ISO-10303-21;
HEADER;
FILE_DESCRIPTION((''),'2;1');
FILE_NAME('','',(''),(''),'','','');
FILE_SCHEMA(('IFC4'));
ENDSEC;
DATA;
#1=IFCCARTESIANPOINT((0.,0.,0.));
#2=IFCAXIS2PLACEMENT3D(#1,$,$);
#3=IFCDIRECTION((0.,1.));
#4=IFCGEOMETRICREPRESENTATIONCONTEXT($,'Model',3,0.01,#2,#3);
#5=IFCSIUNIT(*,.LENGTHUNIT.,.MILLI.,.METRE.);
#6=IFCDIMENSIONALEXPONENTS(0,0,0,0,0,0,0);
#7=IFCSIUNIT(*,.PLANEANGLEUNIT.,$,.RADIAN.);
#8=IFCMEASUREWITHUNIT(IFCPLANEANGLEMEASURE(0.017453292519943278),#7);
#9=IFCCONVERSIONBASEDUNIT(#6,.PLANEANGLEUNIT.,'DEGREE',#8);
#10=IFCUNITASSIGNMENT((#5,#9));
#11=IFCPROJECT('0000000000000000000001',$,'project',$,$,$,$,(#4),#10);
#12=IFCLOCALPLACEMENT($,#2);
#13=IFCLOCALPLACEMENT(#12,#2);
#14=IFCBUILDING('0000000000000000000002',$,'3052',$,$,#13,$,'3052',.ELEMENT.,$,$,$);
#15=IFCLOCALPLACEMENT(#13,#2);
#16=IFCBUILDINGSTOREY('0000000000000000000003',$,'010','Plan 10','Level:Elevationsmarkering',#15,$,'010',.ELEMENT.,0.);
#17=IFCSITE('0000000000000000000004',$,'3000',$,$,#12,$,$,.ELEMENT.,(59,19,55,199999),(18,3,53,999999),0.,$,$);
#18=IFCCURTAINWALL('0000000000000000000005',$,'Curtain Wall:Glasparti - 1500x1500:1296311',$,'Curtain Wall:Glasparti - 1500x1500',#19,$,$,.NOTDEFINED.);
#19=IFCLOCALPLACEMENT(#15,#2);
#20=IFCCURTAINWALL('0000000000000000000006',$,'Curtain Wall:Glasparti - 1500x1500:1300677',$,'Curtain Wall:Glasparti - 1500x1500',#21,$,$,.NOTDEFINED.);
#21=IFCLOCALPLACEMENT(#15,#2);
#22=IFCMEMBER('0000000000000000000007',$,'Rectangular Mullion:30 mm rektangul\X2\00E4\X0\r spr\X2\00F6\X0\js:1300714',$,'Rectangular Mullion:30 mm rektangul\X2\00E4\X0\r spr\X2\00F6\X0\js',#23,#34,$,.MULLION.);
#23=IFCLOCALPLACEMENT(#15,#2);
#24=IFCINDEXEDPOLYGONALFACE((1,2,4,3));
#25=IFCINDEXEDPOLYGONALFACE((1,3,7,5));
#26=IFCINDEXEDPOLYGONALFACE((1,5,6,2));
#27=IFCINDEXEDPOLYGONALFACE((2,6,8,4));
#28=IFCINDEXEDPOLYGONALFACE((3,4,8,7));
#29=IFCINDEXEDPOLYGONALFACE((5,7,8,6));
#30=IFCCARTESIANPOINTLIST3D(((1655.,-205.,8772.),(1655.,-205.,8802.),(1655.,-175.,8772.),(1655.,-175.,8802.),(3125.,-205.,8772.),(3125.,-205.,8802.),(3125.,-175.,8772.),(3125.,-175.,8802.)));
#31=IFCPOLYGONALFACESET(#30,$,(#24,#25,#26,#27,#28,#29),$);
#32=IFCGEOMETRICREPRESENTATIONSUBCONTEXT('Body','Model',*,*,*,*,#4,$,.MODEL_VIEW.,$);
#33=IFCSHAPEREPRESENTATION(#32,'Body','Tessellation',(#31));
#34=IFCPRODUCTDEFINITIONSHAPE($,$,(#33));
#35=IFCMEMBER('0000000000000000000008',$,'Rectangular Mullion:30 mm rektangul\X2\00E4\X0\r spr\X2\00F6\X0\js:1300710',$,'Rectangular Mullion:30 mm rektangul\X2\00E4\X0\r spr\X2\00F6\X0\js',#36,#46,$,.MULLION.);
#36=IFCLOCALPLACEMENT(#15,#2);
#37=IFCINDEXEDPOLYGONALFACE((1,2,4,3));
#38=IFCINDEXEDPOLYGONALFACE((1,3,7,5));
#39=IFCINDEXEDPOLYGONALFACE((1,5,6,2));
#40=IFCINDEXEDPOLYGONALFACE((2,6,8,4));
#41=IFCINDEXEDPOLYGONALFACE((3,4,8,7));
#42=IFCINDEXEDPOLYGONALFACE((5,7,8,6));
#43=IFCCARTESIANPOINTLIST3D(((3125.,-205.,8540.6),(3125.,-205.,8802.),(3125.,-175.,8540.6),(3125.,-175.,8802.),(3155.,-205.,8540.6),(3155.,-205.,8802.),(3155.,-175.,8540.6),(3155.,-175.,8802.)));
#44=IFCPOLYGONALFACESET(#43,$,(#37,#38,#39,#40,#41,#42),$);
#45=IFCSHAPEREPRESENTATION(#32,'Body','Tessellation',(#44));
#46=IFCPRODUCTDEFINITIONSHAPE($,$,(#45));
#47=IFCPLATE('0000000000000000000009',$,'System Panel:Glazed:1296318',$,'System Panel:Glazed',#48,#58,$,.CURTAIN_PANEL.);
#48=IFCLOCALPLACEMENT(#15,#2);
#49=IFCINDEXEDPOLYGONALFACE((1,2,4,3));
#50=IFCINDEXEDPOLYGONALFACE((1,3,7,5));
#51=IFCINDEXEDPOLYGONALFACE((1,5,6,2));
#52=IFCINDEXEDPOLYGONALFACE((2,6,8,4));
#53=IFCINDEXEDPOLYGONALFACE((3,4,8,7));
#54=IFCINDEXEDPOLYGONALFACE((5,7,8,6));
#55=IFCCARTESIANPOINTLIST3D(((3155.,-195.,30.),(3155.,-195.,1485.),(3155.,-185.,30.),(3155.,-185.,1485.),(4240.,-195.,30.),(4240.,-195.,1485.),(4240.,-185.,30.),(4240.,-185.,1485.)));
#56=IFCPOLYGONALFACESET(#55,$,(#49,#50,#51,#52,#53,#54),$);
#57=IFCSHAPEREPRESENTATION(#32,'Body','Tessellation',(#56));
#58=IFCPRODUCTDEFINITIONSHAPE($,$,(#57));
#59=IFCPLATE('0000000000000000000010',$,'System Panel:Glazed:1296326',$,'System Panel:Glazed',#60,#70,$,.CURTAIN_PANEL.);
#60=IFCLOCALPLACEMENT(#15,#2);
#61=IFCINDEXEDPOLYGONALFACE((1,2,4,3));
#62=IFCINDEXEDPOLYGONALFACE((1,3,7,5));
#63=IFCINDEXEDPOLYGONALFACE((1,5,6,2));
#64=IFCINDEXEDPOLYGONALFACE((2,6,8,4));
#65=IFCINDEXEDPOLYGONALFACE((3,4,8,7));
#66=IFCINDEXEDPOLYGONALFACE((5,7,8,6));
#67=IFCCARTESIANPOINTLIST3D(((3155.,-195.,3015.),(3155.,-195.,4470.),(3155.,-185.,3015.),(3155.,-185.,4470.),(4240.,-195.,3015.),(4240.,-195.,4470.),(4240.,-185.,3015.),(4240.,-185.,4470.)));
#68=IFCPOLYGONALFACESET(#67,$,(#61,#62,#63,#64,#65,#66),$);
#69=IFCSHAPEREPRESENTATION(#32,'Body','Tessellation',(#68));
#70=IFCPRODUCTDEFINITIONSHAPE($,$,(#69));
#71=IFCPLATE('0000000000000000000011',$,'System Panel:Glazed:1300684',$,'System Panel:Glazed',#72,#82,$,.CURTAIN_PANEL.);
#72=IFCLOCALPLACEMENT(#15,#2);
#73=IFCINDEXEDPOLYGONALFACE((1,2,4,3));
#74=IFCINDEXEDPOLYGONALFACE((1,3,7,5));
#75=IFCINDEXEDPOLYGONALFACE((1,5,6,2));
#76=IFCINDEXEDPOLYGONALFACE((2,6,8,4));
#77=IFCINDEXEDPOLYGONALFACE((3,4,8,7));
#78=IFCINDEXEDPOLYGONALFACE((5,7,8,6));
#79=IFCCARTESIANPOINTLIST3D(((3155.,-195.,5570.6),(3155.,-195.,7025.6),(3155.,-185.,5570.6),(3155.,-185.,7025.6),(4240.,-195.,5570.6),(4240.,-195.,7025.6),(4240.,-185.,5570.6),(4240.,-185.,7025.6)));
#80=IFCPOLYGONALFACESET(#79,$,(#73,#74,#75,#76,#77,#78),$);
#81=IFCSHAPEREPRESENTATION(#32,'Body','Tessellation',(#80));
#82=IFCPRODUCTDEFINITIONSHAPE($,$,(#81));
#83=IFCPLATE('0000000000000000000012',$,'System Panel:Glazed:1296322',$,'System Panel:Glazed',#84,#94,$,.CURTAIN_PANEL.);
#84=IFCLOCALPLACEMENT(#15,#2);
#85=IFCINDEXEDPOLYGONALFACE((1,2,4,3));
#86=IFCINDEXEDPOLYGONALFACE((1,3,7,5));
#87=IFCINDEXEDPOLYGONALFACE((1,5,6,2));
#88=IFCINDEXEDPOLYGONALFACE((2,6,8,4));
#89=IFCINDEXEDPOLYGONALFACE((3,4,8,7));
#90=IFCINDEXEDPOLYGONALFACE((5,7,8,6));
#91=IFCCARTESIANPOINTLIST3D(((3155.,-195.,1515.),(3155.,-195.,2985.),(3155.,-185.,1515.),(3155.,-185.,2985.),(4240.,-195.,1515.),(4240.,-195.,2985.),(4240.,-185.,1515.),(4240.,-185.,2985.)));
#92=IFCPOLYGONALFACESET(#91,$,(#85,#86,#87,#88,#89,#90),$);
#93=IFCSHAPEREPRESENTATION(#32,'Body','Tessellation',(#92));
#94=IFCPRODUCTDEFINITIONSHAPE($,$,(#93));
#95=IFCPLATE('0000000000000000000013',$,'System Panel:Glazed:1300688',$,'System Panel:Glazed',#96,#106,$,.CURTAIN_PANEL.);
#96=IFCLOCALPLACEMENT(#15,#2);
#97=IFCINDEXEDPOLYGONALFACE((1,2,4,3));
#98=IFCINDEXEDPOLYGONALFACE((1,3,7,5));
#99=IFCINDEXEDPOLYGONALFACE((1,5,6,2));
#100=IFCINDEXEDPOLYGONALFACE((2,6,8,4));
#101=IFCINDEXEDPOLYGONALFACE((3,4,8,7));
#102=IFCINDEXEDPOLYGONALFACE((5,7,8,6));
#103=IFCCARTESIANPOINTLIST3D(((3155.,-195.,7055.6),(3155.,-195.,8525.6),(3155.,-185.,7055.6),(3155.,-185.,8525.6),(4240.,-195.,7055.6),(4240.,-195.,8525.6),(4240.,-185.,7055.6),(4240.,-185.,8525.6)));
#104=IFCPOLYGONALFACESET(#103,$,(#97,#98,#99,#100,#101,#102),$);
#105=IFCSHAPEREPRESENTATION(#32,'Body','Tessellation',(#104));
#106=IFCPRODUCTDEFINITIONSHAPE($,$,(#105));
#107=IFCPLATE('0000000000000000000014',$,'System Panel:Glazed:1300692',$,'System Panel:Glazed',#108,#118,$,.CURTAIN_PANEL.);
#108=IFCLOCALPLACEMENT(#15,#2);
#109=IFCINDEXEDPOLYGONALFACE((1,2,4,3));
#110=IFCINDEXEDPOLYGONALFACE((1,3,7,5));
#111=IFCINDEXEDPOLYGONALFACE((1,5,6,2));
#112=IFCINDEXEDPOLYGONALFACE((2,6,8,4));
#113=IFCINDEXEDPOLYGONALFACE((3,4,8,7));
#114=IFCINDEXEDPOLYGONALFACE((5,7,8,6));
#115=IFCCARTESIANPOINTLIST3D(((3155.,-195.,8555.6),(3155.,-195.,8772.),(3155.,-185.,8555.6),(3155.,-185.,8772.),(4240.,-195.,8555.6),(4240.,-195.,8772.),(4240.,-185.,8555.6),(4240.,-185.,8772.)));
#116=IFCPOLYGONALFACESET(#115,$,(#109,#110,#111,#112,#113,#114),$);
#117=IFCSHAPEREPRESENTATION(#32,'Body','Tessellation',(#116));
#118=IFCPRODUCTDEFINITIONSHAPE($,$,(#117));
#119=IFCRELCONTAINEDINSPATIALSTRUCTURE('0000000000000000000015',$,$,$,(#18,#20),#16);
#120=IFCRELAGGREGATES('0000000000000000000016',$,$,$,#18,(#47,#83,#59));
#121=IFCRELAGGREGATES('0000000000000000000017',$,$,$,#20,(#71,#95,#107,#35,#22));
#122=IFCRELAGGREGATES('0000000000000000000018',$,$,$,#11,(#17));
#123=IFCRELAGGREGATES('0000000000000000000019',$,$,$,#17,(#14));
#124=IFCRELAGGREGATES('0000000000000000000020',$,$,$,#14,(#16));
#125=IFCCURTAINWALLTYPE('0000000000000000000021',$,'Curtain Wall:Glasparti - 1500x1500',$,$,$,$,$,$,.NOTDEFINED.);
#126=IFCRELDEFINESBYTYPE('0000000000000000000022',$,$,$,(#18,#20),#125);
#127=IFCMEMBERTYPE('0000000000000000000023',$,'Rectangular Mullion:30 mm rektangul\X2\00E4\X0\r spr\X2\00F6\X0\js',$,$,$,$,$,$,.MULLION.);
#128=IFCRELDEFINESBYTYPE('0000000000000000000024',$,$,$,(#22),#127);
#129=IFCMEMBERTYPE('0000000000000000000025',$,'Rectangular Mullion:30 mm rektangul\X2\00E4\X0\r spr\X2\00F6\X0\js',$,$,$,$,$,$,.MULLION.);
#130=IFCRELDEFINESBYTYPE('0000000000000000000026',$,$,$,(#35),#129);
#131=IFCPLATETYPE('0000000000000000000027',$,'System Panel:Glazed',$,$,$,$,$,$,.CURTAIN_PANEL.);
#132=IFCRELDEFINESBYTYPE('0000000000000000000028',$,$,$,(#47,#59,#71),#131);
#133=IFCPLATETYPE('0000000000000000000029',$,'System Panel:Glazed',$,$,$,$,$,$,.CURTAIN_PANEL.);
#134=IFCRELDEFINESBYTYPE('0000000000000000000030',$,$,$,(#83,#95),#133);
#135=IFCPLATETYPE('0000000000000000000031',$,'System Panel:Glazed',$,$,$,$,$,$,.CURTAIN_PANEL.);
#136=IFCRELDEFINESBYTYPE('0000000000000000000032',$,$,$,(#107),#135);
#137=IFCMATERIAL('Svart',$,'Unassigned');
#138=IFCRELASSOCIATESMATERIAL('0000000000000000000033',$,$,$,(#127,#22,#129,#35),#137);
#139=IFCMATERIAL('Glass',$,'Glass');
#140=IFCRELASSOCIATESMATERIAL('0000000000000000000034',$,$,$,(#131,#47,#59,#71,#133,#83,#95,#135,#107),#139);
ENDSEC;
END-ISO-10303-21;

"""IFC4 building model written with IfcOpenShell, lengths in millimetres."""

from ifc_helpers import new_model, entity, si_unit, converted_unit, direction, frame, origin, place, context, subcontext, project, spatial, indexed_curve, outline, extrude, source, transform, mapped, material, type_object, type_shapes, element, aggregate, save


model = new_model("IFC4")

# Units and contexts
model_context = context("Model", 3, precision=0.01, world=origin(), true_north=direction((0.0, 1.0)))
body_context = subcontext(model_context, "Body", "Model", "MODEL_VIEW")
ifc_project = project(units=[si_unit("LENGTHUNIT", "METRE", prefix="MILLI"), converted_unit("PLANEANGLEUNIT", "DEGREE", entity("IfcPlaneAngleMeasure", 0.017453292519943278), si_unit("PLANEANGLEUNIT", "RADIAN"), dimensions=[0, 0, 0, 0, 0, 0, 0])], contexts=[model_context])

# Site, building, storey
site_placement = place(None, origin())
site = spatial("IfcSite", under=ifc_project, at=site_placement, Name="3000", CompositionType="ELEMENT", RefLatitude=(59, 19, 55, 199999), RefLongitude=(18, 3, 53, 999999), RefElevation=0.0)
building_placement = place(site_placement, origin())
building = spatial("IfcBuilding", under=site, at=building_placement, Name="3052", LongName="3052", CompositionType="ELEMENT")
storey_placement = place(building_placement, origin())
storey = spatial("IfcBuildingStorey", under=building, at=storey_placement, Name="010", Description="Plan 10", ObjectType="Level:Elevationsmarkering", LongName="010", CompositionType="ELEMENT", Elevation=0.0)

# Curtain walls
curtain_wall_type = type_object("IfcCurtainWallType", Name="Curtain Wall:Glasparti - 1500x1500", PredefinedType="NOTDEFINED")
curtain_wall_1_placement = place(storey_placement, origin())
curtain_wall_1 = element("IfcCurtainWall", 1, at=curtain_wall_1_placement, inside=storey, type_object=curtain_wall_type, Name="Curtain Wall:Glasparti - 1500x1500:1296311", ObjectType="Curtain Wall:Glasparti - 1500x1500", PredefinedType="NOTDEFINED")
ifc_material_1 = material(Name="Svart", Category="Unassigned")
curtain_wall_2_placement = place(storey_placement, origin())
curtain_wall_2 = element("IfcCurtainWall", 2, at=curtain_wall_2_placement, inside=storey, type_object=curtain_wall_type, Name="Curtain Wall:Glasparti - 1500x1500:1300677", ObjectType="Curtain Wall:Glasparti - 1500x1500", PredefinedType="NOTDEFINED")

# Members
member_type_1 = type_object("IfcMemberType", Name="Rectangular Mullion:30 mm rektangulär spröjs", PredefinedType="MULLION", material=ifc_material_1)
shared_shape_1 = source(origin(), body_context, "Body", "SweptSolid", [
    extrude(outline(indexed_curve([(-15.0, -15.0), (15.0, -15.0), (15.0, 15.0), (-15.0, 15.0), (-15.0, -15.0)], self_intersect=False)), frame((-15.0, 0.0, -1470.0), z_axis=(0.0, 0.0, 1.0), x_axis=(-1.0, 0.0, 0.0)), (0.0, 0.0, 1.0), 1470.0),
])
type_shapes(member_type_1, [shared_shape_1])
member_1_placement = place(curtain_wall_2_placement, frame((3125.0, -190.0, 8802.0), z_axis=(1.0, 0.0, 0.0), x_axis=(0.0, 0.0, 1.0)))
member_1 = element("IfcMember", 3, at=member_1_placement, type_object=member_type_1, material=ifc_material_1, Name="Rectangular Mullion:30 mm rektangulär spröjs:1300714", ObjectType="Rectangular Mullion:30 mm rektangulär spröjs", PredefinedType="MULLION", context=body_context, shape_type="MappedRepresentation", body=[
    mapped(shared_shape_1, transform((0.0, 0.0, 0.0), scale=1.0)),
])
member_type_2 = type_object("IfcMemberType", Name="Rectangular Mullion:30 mm rektangulär spröjs", PredefinedType="MULLION", material=ifc_material_1)
shared_shape_2 = source(origin(), body_context, "Body", "SweptSolid", [
    extrude(outline(indexed_curve([(-15.0, -15.0), (15.0, -15.0), (15.0, 15.0), (-15.0, 15.0), (-15.0, -15.0)], self_intersect=False)), frame((0.0, 0.0, -261.4), z_axis=(0.0, 0.0, 1.0), x_axis=(-1.0, 0.0, 0.0)), (0.0, 0.0, 1.0), 261.4),
])
type_shapes(member_type_2, [shared_shape_2])
member_2_placement = place(curtain_wall_2_placement, frame((3140.0, -190.0, 8540.6), z_axis=(0.0, 0.0, -1.0), x_axis=(1.0, 0.0, 0.0)))
member_2 = element("IfcMember", 4, at=member_2_placement, type_object=member_type_2, material=ifc_material_1, Name="Rectangular Mullion:30 mm rektangulär spröjs:1300710", ObjectType="Rectangular Mullion:30 mm rektangulär spröjs", PredefinedType="MULLION", context=body_context, shape_type="MappedRepresentation", body=[
    mapped(shared_shape_2, transform((0.0, 0.0, 0.0), scale=1.0)),
])

# Plates
ifc_material_2 = material(Name="Glass", Category="Glass")
plate_type_1 = type_object("IfcPlateType", Name="System Panel:Glazed", PredefinedType="CURTAIN_PANEL", material=ifc_material_2)
shared_shape_3 = source(origin(), body_context, "Body", "SweptSolid", [
    extrude(outline(indexed_curve([(-5.0, -542.5), (5.0, -542.5), (5.0, 542.5), (-5.0, 542.5), (-5.0, -542.5)], self_intersect=False)), frame((0.0, 0.0, 0.0), z_axis=(0.0, 0.0, 1.0), x_axis=(0.0, 1.0, 0.0)), (0.0, 0.0, 1.0), 1455.0),
])
type_shapes(plate_type_1, [shared_shape_3])
plate_1_placement = place(curtain_wall_1_placement, frame((3697.5, -190.0, 30.0)))
plate_1 = element("IfcPlate", 5, at=plate_1_placement, type_object=plate_type_1, material=ifc_material_2, Name="System Panel:Glazed:1296318", ObjectType="System Panel:Glazed", PredefinedType="CURTAIN_PANEL", context=body_context, shape_type="MappedRepresentation", body=[
    mapped(shared_shape_3, transform((0.0, 0.0, 0.0), scale=1.0)),
])
plate_2_placement = place(curtain_wall_1_placement, frame((3697.5, -190.0, 3015.0)))
plate_2 = element("IfcPlate", 6, at=plate_2_placement, type_object=plate_type_1, material=ifc_material_2, Name="System Panel:Glazed:1296326", ObjectType="System Panel:Glazed", PredefinedType="CURTAIN_PANEL", context=body_context, shape_type="MappedRepresentation", body=[
    mapped(shared_shape_3, transform((0.0, 0.0, 0.0), scale=1.0)),
])
plate_3_placement = place(curtain_wall_2_placement, frame((3697.5, -190.0, 5570.6)))
plate_3 = element("IfcPlate", 7, at=plate_3_placement, type_object=plate_type_1, material=ifc_material_2, Name="System Panel:Glazed:1300684", ObjectType="System Panel:Glazed", PredefinedType="CURTAIN_PANEL", context=body_context, shape_type="MappedRepresentation", body=[
    mapped(shared_shape_3, transform((0.0, 0.0, 0.0), scale=1.0)),
])
plate_type_2 = type_object("IfcPlateType", Name="System Panel:Glazed", PredefinedType="CURTAIN_PANEL", material=ifc_material_2)
shared_shape_4 = source(origin(), body_context, "Body", "SweptSolid", [
    extrude(outline(indexed_curve([(-5.0, -542.5), (5.0, -542.5), (5.0, 542.5), (-5.0, 542.5), (-5.0, -542.5)], self_intersect=False)), frame((0.0, 0.0, 0.0), z_axis=(0.0, 0.0, 1.0), x_axis=(0.0, 1.0, 0.0)), (0.0, 0.0, 1.0), 1470.0),
])
type_shapes(plate_type_2, [shared_shape_4])
plate_4_placement = place(curtain_wall_1_placement, frame((3697.5, -190.0, 1515.0)))
plate_4 = element("IfcPlate", 8, at=plate_4_placement, type_object=plate_type_2, material=ifc_material_2, Name="System Panel:Glazed:1296322", ObjectType="System Panel:Glazed", PredefinedType="CURTAIN_PANEL", context=body_context, shape_type="MappedRepresentation", body=[
    mapped(shared_shape_4, transform((0.0, 0.0, 0.0), scale=1.0)),
])
aggregate(curtain_wall_1, [plate_1, plate_4, plate_2])
plate_5_placement = place(curtain_wall_2_placement, frame((3697.5, -190.0, 7055.6)))
plate_5 = element("IfcPlate", 9, at=plate_5_placement, type_object=plate_type_2, material=ifc_material_2, Name="System Panel:Glazed:1300688", ObjectType="System Panel:Glazed", PredefinedType="CURTAIN_PANEL", context=body_context, shape_type="MappedRepresentation", body=[
    mapped(shared_shape_4, transform((0.0, 0.0, 0.0), scale=1.0)),
])
plate_type_3 = type_object("IfcPlateType", Name="System Panel:Glazed", PredefinedType="CURTAIN_PANEL", material=ifc_material_2)
shared_shape_5 = source(origin(), body_context, "Body", "SweptSolid", [
    extrude(outline(indexed_curve([(-5.0, -542.5), (5.0, -542.5), (5.0, 542.5), (-5.0, 542.5), (-5.0, -542.5)], self_intersect=False)), frame((0.0, 0.0, 0.0), z_axis=(0.0, 0.0, 1.0), x_axis=(0.0, 1.0, 0.0)), (0.0, 0.0, 1.0), 216.4),
])
type_shapes(plate_type_3, [shared_shape_5])
plate_6_placement = place(curtain_wall_2_placement, frame((3697.5, -190.0, 8555.6)))
plate_6 = element("IfcPlate", 10, at=plate_6_placement, type_object=plate_type_3, material=ifc_material_2, Name="System Panel:Glazed:1300692", ObjectType="System Panel:Glazed", PredefinedType="CURTAIN_PANEL", context=body_context, shape_type="MappedRepresentation", body=[
    mapped(shared_shape_5, transform((0.0, 0.0, 0.0), scale=1.0)),
])
aggregate(curtain_wall_2, [plate_3, plate_5, plate_6, member_2, member_1])

save(model, "model.ifc")
